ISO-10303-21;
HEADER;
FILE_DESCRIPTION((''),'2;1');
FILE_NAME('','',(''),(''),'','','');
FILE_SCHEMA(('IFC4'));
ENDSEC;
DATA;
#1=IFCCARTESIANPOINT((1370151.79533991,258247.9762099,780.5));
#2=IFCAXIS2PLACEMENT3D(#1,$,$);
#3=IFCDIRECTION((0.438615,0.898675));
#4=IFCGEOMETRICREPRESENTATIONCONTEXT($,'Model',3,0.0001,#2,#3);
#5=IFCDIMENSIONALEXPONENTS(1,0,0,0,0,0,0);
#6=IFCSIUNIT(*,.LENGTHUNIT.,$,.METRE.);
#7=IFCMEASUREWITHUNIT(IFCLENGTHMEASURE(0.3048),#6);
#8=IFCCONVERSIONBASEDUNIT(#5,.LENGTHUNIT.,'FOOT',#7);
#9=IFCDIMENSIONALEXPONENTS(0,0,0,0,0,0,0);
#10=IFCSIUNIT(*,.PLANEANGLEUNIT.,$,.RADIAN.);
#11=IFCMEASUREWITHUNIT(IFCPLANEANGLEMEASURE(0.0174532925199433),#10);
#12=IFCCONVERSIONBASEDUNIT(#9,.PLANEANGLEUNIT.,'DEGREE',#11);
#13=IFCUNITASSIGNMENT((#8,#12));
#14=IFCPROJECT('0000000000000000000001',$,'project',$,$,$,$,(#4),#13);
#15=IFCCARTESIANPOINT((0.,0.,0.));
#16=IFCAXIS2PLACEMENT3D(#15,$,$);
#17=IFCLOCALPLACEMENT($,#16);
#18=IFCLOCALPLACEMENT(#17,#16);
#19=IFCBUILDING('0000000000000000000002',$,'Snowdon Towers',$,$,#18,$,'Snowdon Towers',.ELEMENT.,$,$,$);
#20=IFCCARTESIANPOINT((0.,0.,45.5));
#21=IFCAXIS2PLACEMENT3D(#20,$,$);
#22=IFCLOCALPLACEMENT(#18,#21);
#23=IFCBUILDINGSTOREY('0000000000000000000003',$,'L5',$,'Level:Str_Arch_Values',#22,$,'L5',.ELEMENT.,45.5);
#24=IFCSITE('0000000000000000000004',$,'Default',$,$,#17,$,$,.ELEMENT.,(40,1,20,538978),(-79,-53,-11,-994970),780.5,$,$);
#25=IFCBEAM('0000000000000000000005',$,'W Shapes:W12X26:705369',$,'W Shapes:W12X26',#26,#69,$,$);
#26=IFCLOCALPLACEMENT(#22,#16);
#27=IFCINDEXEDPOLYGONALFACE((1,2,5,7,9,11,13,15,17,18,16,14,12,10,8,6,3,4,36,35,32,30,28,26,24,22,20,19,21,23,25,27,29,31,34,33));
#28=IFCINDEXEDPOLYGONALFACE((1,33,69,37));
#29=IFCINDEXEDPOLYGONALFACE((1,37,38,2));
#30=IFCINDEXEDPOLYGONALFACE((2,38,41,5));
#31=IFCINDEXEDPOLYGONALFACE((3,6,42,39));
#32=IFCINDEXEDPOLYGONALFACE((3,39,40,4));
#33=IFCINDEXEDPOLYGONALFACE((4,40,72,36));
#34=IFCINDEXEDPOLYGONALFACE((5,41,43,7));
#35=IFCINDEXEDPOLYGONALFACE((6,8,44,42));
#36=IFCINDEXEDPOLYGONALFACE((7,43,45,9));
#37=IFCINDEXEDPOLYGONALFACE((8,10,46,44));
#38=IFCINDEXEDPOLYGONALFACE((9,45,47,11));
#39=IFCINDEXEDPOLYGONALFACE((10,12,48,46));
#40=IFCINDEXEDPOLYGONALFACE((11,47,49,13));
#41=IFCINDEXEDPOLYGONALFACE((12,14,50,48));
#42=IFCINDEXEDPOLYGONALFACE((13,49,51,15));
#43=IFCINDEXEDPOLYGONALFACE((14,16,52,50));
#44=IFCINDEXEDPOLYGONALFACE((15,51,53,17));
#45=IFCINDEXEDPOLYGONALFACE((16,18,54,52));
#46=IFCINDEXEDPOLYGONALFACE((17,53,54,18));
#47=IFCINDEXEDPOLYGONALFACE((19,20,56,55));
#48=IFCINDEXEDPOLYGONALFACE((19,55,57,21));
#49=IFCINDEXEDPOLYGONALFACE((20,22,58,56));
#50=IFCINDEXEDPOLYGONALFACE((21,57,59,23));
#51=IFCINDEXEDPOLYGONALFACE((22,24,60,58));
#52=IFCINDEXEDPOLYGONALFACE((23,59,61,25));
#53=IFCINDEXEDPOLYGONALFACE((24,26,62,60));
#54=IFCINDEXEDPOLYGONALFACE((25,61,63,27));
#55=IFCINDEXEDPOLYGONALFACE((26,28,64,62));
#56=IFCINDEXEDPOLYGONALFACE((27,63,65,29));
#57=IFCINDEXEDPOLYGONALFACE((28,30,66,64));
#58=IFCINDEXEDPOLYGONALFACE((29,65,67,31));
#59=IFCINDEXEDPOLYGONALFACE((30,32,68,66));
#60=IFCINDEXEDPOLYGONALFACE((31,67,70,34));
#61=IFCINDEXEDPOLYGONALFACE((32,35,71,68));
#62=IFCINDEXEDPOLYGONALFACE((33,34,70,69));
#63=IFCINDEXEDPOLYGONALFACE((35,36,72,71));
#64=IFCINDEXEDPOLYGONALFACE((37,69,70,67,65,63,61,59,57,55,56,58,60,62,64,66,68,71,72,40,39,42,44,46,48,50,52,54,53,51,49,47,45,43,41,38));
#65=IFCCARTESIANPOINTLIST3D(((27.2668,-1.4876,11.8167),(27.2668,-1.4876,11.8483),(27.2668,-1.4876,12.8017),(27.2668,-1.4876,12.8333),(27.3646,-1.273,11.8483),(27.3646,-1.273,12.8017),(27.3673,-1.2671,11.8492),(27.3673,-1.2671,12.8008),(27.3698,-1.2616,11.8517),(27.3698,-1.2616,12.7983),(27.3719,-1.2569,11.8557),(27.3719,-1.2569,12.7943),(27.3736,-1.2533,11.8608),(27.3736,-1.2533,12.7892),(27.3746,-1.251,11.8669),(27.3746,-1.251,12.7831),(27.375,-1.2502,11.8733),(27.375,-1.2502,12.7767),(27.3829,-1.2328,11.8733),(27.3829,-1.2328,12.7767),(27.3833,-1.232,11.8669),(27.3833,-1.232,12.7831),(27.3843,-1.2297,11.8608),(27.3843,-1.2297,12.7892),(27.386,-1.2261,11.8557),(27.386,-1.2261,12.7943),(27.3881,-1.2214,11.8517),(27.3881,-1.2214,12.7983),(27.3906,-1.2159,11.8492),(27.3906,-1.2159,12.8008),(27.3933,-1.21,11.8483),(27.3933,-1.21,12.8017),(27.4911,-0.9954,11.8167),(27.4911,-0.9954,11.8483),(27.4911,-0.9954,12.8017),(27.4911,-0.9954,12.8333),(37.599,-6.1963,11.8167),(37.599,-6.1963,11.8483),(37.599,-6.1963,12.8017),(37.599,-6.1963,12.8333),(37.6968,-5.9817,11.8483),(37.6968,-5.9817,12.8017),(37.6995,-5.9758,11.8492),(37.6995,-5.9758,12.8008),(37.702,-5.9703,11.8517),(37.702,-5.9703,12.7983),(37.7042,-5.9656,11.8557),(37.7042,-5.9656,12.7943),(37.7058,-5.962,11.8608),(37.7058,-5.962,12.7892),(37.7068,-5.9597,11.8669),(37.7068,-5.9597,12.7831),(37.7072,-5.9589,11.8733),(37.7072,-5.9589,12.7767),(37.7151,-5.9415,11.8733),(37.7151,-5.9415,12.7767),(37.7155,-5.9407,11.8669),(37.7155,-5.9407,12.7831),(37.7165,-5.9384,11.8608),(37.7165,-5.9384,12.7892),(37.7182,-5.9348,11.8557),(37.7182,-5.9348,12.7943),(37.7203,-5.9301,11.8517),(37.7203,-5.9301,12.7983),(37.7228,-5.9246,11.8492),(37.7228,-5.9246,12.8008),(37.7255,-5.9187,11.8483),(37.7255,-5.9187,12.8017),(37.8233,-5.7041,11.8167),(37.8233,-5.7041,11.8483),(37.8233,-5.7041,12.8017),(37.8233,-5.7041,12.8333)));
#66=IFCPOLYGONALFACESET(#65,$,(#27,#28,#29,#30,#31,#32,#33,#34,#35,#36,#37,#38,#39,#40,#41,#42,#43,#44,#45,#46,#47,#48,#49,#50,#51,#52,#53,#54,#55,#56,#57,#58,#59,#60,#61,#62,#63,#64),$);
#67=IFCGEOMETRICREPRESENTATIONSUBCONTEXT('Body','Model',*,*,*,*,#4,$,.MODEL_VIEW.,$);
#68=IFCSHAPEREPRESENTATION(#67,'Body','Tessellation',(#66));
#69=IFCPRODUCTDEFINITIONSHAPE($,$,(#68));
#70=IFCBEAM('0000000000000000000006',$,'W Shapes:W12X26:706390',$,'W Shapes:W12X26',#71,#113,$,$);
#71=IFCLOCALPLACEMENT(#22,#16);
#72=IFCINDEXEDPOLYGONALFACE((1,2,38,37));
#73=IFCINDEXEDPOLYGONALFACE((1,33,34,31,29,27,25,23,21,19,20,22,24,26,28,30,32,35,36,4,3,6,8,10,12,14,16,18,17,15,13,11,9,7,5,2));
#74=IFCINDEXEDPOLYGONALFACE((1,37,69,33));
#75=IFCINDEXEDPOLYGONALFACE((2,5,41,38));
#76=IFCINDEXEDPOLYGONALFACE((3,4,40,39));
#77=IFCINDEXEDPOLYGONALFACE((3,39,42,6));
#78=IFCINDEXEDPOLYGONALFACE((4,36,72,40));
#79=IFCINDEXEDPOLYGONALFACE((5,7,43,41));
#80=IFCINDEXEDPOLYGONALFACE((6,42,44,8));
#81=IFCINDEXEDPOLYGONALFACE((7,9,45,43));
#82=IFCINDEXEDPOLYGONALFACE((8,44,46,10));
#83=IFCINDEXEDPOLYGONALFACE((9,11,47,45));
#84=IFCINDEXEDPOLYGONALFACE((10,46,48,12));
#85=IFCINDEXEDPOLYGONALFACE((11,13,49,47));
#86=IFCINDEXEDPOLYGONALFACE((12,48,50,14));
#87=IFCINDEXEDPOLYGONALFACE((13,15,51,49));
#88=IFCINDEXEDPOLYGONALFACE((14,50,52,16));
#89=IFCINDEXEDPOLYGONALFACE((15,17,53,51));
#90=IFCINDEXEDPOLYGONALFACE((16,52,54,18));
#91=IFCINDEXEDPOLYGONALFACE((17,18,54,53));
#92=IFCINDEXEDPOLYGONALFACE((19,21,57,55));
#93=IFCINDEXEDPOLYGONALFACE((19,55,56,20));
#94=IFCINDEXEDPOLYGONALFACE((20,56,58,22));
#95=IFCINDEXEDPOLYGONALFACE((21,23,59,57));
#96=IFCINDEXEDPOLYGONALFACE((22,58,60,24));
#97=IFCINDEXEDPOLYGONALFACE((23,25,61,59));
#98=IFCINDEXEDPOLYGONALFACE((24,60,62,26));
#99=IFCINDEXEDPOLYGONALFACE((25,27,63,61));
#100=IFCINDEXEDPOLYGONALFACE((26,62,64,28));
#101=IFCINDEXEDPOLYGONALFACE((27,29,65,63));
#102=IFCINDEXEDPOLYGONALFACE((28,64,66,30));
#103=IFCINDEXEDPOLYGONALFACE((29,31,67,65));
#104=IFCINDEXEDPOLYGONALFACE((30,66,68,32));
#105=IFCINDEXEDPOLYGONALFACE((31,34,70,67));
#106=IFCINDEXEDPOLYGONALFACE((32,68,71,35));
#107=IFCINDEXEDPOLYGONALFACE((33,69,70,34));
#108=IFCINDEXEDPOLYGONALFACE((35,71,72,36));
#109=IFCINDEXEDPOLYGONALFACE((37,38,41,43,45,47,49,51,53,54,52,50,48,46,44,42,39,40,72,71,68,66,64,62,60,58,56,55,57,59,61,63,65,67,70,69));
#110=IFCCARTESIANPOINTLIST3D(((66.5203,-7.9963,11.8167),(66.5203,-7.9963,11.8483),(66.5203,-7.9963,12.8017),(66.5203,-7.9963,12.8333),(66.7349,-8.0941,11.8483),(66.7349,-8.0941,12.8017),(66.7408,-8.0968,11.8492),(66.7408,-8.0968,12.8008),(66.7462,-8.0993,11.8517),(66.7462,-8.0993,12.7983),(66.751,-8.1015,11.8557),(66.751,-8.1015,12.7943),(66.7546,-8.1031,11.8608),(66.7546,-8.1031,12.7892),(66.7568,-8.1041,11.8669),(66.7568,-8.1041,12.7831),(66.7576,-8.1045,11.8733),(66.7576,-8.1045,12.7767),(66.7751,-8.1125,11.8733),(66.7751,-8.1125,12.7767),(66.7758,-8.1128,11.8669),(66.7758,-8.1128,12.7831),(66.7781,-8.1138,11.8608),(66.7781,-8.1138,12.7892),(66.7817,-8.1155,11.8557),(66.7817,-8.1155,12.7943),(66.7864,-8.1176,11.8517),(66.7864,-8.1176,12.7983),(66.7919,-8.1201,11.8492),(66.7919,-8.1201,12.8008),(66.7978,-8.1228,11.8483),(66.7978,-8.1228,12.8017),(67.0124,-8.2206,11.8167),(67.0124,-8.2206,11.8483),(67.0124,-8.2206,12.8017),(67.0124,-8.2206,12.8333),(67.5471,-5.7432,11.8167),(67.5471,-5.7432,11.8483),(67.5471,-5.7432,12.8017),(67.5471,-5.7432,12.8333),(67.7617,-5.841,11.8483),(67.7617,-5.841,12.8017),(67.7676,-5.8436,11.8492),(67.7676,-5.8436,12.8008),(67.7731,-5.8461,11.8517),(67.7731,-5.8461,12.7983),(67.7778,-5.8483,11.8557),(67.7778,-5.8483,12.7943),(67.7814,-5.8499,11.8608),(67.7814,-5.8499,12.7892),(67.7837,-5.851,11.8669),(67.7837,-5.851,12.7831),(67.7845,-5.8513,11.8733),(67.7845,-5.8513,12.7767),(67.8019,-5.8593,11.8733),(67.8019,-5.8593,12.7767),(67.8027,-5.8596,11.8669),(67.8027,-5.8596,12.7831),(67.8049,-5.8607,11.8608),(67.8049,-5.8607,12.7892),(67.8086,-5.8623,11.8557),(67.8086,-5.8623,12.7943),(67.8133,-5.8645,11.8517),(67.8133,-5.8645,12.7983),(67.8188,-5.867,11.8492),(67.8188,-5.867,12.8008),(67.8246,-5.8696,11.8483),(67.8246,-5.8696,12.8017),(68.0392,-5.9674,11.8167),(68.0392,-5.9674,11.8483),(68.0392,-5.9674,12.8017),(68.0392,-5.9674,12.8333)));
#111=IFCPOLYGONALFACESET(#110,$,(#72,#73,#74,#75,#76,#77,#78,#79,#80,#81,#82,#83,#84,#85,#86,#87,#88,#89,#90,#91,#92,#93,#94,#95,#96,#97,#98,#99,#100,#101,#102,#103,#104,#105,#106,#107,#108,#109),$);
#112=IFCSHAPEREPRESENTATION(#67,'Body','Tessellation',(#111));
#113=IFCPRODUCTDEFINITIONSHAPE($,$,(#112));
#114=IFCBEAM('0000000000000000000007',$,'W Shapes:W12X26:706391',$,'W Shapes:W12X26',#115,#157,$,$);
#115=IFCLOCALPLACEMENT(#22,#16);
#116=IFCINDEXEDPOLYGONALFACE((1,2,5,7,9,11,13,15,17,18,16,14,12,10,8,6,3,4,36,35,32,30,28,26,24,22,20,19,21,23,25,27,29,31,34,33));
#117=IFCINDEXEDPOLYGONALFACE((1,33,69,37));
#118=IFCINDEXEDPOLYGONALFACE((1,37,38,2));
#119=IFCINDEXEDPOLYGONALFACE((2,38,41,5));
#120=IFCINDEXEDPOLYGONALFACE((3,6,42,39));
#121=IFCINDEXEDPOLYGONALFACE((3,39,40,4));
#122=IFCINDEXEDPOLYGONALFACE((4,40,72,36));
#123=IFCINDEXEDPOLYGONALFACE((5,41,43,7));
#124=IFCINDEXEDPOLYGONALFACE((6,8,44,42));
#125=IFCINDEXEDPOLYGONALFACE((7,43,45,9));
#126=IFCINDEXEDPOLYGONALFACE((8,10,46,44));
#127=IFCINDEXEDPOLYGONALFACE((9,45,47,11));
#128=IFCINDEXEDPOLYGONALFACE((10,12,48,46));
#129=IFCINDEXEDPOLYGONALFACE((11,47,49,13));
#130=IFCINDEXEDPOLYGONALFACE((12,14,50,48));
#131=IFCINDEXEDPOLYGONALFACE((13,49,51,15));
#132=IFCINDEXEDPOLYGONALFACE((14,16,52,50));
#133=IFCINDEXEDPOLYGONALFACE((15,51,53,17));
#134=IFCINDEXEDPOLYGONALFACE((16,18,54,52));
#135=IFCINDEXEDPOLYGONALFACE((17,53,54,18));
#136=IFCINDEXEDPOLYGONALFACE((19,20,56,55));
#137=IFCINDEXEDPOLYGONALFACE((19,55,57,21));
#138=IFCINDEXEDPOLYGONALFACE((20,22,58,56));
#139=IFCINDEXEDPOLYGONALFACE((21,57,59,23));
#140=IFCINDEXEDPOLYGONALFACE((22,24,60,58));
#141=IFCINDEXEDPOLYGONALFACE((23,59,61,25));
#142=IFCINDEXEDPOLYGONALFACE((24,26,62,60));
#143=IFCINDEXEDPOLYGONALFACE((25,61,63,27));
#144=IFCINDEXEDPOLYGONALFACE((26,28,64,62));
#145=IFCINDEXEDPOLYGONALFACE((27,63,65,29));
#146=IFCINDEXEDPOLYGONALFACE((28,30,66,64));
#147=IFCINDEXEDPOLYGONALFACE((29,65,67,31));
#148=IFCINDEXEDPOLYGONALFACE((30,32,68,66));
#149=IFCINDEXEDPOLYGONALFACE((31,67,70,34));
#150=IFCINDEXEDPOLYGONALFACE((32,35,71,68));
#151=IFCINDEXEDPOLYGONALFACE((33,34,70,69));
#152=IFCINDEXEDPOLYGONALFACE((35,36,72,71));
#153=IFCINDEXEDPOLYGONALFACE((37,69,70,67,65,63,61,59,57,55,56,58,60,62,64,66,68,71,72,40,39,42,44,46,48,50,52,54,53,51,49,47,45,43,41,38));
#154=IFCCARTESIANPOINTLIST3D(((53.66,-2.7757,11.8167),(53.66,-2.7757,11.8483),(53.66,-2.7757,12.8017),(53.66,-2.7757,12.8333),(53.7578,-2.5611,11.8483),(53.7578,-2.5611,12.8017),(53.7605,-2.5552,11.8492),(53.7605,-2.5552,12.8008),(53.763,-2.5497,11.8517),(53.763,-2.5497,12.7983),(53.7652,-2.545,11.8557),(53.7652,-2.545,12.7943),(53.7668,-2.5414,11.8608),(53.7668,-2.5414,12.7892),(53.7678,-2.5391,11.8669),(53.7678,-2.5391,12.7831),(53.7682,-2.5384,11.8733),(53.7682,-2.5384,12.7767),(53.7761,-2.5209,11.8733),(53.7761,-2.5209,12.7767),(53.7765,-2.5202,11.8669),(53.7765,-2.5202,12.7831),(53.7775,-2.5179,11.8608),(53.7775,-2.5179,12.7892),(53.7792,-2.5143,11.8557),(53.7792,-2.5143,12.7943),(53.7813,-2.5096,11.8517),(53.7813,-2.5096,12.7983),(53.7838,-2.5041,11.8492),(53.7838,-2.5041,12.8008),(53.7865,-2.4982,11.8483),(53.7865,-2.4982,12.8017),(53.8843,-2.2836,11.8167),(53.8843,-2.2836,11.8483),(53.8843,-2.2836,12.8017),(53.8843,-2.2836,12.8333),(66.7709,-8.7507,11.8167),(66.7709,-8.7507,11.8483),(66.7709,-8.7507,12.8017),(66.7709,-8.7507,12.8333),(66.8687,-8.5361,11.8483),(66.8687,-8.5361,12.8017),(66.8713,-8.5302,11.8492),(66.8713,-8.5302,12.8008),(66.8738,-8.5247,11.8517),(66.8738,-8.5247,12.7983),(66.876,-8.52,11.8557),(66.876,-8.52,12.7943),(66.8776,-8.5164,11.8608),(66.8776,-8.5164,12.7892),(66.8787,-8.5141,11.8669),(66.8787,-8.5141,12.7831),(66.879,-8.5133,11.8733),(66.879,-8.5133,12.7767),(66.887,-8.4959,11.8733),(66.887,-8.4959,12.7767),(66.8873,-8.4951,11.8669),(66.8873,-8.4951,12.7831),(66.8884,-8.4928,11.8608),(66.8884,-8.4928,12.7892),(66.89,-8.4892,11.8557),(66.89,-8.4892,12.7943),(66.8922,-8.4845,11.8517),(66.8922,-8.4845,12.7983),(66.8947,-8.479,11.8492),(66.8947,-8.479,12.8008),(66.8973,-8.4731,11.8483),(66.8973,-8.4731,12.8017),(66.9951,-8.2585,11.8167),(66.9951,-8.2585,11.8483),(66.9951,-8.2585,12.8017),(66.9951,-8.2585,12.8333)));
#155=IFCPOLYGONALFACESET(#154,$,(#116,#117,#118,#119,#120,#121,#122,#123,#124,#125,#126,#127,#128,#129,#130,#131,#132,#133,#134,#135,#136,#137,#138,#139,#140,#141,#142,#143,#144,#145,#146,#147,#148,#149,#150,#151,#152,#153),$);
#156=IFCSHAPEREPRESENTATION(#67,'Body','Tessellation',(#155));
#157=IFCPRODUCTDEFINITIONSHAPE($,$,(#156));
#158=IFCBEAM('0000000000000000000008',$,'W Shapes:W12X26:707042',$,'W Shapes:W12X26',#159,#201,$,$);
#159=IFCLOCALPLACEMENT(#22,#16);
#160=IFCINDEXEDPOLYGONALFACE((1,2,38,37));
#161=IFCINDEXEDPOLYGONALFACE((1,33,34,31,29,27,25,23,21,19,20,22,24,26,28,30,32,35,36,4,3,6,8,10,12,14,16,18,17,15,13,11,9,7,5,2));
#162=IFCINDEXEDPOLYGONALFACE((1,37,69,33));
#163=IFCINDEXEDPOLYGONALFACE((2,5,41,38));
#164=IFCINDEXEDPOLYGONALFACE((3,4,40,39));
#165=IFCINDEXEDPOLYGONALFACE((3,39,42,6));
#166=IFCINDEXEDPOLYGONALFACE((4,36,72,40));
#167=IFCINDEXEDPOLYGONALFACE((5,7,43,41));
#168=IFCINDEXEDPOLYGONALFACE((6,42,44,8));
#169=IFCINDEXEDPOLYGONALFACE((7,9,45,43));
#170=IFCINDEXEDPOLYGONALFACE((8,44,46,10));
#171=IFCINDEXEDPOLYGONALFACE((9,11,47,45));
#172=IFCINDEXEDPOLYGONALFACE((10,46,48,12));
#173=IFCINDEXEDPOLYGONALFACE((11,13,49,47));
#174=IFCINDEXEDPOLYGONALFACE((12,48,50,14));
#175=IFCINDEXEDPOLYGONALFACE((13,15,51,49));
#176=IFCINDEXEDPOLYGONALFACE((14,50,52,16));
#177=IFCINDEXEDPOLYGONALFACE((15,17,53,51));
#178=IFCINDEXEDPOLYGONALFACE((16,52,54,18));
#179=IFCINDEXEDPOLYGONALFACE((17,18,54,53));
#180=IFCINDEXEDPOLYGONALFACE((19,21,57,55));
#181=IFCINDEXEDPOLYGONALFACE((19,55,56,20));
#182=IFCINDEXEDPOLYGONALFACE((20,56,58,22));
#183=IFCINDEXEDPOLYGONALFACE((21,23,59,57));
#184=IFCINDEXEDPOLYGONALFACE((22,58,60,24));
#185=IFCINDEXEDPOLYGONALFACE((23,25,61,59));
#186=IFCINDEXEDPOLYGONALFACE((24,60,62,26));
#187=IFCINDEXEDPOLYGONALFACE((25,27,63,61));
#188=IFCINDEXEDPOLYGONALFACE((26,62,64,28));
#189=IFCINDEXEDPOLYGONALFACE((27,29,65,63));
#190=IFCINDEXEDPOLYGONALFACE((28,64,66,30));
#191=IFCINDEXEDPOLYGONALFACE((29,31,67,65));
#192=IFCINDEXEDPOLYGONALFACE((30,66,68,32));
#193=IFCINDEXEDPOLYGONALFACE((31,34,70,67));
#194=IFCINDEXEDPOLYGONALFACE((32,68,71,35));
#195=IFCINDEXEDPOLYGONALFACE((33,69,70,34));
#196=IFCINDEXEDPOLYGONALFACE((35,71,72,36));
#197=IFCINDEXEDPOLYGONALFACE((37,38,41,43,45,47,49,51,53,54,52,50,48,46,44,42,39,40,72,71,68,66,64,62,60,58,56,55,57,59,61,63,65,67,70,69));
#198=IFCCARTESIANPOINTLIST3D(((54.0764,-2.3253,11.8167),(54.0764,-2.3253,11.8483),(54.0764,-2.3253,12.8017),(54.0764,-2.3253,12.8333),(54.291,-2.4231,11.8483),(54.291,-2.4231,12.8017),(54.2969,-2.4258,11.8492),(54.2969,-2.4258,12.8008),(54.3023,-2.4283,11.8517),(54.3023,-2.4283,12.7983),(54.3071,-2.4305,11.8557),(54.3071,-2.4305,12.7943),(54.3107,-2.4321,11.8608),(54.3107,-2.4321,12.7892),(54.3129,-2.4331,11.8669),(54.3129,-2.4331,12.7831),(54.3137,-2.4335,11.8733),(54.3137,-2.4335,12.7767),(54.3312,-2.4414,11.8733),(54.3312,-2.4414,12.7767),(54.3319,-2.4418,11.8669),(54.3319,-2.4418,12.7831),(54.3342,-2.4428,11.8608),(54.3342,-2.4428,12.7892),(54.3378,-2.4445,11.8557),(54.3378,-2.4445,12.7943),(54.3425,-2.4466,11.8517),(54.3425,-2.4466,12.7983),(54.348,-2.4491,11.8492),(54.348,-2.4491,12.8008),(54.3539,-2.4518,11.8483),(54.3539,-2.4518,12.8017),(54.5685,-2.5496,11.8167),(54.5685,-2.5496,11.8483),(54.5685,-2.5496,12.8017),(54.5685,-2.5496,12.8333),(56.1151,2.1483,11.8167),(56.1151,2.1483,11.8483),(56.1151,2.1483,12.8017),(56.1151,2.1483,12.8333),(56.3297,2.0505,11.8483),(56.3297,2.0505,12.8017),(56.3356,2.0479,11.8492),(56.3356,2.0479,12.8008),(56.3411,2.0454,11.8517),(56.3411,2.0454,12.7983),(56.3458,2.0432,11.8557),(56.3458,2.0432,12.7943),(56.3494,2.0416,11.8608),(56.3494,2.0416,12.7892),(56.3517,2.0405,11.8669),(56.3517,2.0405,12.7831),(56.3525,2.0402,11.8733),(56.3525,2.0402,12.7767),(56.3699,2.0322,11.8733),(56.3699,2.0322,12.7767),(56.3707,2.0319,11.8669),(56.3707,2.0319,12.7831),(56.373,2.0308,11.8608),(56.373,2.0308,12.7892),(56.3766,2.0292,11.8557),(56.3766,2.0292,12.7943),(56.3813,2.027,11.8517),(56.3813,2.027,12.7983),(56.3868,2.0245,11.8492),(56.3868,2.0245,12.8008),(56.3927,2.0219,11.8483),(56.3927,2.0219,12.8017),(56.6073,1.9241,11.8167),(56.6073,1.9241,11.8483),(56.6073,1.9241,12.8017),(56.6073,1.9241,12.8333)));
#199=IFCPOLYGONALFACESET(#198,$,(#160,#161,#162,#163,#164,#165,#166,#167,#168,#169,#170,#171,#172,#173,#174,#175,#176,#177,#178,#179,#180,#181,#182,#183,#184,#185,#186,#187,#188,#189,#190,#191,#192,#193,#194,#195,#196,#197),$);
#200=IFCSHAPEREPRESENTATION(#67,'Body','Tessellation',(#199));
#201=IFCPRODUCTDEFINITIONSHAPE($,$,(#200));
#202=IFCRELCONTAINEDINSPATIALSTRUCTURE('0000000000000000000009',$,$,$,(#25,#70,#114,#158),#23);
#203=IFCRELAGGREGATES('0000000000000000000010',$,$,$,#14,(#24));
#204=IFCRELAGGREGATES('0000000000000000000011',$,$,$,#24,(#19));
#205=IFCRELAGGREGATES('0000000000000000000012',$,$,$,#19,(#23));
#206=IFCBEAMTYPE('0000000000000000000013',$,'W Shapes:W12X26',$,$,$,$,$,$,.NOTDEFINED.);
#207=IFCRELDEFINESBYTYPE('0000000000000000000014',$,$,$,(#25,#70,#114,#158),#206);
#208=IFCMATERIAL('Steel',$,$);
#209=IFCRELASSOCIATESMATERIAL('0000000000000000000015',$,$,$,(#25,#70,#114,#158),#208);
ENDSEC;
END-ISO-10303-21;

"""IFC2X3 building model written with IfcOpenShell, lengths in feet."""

from ifc_helpers import new_model, entity, si_unit, converted_unit, direction, frame, frame_2d, origin, place, context, subcontext, project, spatial, i_section, extrude, material, type_object, element, save


model = new_model("IFC2X3")

# Units and contexts
model_context = context("Model", 3, precision=0.0001, world=frame((1370151.79533991, 258247.9762099, 780.5)), true_north=direction((0.438615, 0.898675)))
body_context = subcontext(model_context, "Body", "Model", "MODEL_VIEW")
ifc_project = project(units=[converted_unit("LENGTHUNIT", "FOOT", entity("IfcLengthMeasure", 0.3048), si_unit("LENGTHUNIT", "METRE"), dimensions=[1, 0, 0, 0, 0, 0, 0]), converted_unit("PLANEANGLEUNIT", "DEGREE", entity("IfcPlaneAngleMeasure", 0.0174532925199433), si_unit("PLANEANGLEUNIT", "RADIAN"), dimensions=[0, 0, 0, 0, 0, 0, 0])], contexts=[model_context])

# Site, building, storey
site_placement = place(None, origin())
site = spatial("IfcSite", under=ifc_project, at=site_placement, Name="Default", CompositionType="ELEMENT", RefLatitude=(40, 1, 20, 538978), RefLongitude=(-79, -53, -11, -994970), RefElevation=780.5)
building_placement = place(site_placement, origin())
building = spatial("IfcBuilding", under=site, at=building_placement, Name="Snowdon Towers", LongName="Snowdon Towers", CompositionType="ELEMENT")
storey_placement = place(building_placement, frame((0.0, 0.0, 45.5)))
storey = spatial("IfcBuildingStorey", under=building, at=storey_placement, Name="L5", ObjectType="Level:Str_Arch_Values", LongName="L5", CompositionType="ELEMENT", Elevation=45.5)

# Shared definitions
ifc_material = material(Name="Steel")

# Beams
beam_type_1 = type_object("IfcBeamType", Name="W Shapes:W12X26", PredefinedType="NOTDEFINED")
beam_1_placement = place(storey_placement, frame((27.1329, -1.1294, 12.8333), z_axis=(0.0, 0.0, 1.0), x_axis=(0.909961, -0.414693, 0.0)))
element("IfcBeam", 1, at=beam_1_placement, inside=storey, type_object=beam_type_1, material=ifc_material, Name="W Shapes:W12X26:705369", ObjectType="W Shapes:W12X26", context=body_context, shape_type="SweptSolid", body=[
    extrude(i_section(OverallWidth=0.5408, OverallDepth=1.0167, WebThickness=0.0192, FlangeThickness=0.0317, FilletRadius=0.025, at=frame_2d((0.0, 0.0), x_axis=(0.0, 1.0))), frame((0.2704, 0.0, -0.5083), z_axis=(1.0, 0.0, 0.0), x_axis=(0.0, 0.0, -1.0)), (0.0, 0.0, 1.0), 11.3546),
])
beam_2_placement = place(storey_placement, frame((66.6369, -8.3925, 12.8333), z_axis=(0.0, 0.0, 1.0), x_axis=(0.414693, 0.909961, 0.0)))
element("IfcBeam", 2, at=beam_2_placement, inside=storey, type_object=beam_type_1, material=ifc_material, Name="W Shapes:W12X26:706390", ObjectType="W Shapes:W12X26", context=body_context, shape_type="SweptSolid", body=[
    extrude(i_section(OverallWidth=0.5408, OverallDepth=1.0167, WebThickness=0.0192, FlangeThickness=0.0317, FilletRadius=0.025, at=frame_2d((0.0, 0.0), x_axis=(0.0, 1.0))), frame((0.3121, 0.0, -0.5083), z_axis=(1.0, 0.0, 0.0), x_axis=(0.0, 0.0, -1.0)), (0.0, 0.0, 1.0), 2.4761),
])
beam_3_placement = place(storey_placement, frame((53.7722, -2.5297, 12.8333), z_axis=(0.0, 0.0, 1.0), x_axis=(0.909961, -0.414693, 0.0)))
element("IfcBeam", 3, at=beam_3_placement, inside=storey, type_object=beam_type_1, material=ifc_material, Name="W Shapes:W12X26:706391", ObjectType="W Shapes:W12X26", context=body_context, shape_type="SweptSolid", body=[
    extrude(i_section(OverallWidth=0.5408, OverallDepth=1.0167, WebThickness=0.0192, FlangeThickness=0.0317, FilletRadius=0.025, at=frame_2d((0.0, 0.0), x_axis=(0.0, 1.0))), frame((0.0, 0.0, -0.5083), z_axis=(1.0, 0.0, 0.0), x_axis=(0.0, 0.0, -1.0)), (0.0, 0.0, 1.0), 14.4081),
])
beam_4_placement = place(storey_placement, frame((54.193, -2.7214, 12.8333), z_axis=(0.0, 0.0, 1.0), x_axis=(0.414693, 0.909961, 0.0)))
element("IfcBeam", 4, at=beam_4_placement, inside=storey, type_object=beam_type_1, material=ifc_material, Name="W Shapes:W12X26:707042", ObjectType="W Shapes:W12X26", context=body_context, shape_type="SweptSolid", body=[
    extrude(i_section(OverallWidth=0.5408, OverallDepth=1.0167, WebThickness=0.0192, FlangeThickness=0.0317, FilletRadius=0.025, at=frame_2d((0.0, 0.0), x_axis=(0.0, 1.0))), frame((0.3121, 0.0, -0.5083), z_axis=(1.0, 0.0, 0.0), x_axis=(0.0, 0.0, -1.0)), (0.0, 0.0, 1.0), 4.9163),
])

save(model, "model.ifc")
